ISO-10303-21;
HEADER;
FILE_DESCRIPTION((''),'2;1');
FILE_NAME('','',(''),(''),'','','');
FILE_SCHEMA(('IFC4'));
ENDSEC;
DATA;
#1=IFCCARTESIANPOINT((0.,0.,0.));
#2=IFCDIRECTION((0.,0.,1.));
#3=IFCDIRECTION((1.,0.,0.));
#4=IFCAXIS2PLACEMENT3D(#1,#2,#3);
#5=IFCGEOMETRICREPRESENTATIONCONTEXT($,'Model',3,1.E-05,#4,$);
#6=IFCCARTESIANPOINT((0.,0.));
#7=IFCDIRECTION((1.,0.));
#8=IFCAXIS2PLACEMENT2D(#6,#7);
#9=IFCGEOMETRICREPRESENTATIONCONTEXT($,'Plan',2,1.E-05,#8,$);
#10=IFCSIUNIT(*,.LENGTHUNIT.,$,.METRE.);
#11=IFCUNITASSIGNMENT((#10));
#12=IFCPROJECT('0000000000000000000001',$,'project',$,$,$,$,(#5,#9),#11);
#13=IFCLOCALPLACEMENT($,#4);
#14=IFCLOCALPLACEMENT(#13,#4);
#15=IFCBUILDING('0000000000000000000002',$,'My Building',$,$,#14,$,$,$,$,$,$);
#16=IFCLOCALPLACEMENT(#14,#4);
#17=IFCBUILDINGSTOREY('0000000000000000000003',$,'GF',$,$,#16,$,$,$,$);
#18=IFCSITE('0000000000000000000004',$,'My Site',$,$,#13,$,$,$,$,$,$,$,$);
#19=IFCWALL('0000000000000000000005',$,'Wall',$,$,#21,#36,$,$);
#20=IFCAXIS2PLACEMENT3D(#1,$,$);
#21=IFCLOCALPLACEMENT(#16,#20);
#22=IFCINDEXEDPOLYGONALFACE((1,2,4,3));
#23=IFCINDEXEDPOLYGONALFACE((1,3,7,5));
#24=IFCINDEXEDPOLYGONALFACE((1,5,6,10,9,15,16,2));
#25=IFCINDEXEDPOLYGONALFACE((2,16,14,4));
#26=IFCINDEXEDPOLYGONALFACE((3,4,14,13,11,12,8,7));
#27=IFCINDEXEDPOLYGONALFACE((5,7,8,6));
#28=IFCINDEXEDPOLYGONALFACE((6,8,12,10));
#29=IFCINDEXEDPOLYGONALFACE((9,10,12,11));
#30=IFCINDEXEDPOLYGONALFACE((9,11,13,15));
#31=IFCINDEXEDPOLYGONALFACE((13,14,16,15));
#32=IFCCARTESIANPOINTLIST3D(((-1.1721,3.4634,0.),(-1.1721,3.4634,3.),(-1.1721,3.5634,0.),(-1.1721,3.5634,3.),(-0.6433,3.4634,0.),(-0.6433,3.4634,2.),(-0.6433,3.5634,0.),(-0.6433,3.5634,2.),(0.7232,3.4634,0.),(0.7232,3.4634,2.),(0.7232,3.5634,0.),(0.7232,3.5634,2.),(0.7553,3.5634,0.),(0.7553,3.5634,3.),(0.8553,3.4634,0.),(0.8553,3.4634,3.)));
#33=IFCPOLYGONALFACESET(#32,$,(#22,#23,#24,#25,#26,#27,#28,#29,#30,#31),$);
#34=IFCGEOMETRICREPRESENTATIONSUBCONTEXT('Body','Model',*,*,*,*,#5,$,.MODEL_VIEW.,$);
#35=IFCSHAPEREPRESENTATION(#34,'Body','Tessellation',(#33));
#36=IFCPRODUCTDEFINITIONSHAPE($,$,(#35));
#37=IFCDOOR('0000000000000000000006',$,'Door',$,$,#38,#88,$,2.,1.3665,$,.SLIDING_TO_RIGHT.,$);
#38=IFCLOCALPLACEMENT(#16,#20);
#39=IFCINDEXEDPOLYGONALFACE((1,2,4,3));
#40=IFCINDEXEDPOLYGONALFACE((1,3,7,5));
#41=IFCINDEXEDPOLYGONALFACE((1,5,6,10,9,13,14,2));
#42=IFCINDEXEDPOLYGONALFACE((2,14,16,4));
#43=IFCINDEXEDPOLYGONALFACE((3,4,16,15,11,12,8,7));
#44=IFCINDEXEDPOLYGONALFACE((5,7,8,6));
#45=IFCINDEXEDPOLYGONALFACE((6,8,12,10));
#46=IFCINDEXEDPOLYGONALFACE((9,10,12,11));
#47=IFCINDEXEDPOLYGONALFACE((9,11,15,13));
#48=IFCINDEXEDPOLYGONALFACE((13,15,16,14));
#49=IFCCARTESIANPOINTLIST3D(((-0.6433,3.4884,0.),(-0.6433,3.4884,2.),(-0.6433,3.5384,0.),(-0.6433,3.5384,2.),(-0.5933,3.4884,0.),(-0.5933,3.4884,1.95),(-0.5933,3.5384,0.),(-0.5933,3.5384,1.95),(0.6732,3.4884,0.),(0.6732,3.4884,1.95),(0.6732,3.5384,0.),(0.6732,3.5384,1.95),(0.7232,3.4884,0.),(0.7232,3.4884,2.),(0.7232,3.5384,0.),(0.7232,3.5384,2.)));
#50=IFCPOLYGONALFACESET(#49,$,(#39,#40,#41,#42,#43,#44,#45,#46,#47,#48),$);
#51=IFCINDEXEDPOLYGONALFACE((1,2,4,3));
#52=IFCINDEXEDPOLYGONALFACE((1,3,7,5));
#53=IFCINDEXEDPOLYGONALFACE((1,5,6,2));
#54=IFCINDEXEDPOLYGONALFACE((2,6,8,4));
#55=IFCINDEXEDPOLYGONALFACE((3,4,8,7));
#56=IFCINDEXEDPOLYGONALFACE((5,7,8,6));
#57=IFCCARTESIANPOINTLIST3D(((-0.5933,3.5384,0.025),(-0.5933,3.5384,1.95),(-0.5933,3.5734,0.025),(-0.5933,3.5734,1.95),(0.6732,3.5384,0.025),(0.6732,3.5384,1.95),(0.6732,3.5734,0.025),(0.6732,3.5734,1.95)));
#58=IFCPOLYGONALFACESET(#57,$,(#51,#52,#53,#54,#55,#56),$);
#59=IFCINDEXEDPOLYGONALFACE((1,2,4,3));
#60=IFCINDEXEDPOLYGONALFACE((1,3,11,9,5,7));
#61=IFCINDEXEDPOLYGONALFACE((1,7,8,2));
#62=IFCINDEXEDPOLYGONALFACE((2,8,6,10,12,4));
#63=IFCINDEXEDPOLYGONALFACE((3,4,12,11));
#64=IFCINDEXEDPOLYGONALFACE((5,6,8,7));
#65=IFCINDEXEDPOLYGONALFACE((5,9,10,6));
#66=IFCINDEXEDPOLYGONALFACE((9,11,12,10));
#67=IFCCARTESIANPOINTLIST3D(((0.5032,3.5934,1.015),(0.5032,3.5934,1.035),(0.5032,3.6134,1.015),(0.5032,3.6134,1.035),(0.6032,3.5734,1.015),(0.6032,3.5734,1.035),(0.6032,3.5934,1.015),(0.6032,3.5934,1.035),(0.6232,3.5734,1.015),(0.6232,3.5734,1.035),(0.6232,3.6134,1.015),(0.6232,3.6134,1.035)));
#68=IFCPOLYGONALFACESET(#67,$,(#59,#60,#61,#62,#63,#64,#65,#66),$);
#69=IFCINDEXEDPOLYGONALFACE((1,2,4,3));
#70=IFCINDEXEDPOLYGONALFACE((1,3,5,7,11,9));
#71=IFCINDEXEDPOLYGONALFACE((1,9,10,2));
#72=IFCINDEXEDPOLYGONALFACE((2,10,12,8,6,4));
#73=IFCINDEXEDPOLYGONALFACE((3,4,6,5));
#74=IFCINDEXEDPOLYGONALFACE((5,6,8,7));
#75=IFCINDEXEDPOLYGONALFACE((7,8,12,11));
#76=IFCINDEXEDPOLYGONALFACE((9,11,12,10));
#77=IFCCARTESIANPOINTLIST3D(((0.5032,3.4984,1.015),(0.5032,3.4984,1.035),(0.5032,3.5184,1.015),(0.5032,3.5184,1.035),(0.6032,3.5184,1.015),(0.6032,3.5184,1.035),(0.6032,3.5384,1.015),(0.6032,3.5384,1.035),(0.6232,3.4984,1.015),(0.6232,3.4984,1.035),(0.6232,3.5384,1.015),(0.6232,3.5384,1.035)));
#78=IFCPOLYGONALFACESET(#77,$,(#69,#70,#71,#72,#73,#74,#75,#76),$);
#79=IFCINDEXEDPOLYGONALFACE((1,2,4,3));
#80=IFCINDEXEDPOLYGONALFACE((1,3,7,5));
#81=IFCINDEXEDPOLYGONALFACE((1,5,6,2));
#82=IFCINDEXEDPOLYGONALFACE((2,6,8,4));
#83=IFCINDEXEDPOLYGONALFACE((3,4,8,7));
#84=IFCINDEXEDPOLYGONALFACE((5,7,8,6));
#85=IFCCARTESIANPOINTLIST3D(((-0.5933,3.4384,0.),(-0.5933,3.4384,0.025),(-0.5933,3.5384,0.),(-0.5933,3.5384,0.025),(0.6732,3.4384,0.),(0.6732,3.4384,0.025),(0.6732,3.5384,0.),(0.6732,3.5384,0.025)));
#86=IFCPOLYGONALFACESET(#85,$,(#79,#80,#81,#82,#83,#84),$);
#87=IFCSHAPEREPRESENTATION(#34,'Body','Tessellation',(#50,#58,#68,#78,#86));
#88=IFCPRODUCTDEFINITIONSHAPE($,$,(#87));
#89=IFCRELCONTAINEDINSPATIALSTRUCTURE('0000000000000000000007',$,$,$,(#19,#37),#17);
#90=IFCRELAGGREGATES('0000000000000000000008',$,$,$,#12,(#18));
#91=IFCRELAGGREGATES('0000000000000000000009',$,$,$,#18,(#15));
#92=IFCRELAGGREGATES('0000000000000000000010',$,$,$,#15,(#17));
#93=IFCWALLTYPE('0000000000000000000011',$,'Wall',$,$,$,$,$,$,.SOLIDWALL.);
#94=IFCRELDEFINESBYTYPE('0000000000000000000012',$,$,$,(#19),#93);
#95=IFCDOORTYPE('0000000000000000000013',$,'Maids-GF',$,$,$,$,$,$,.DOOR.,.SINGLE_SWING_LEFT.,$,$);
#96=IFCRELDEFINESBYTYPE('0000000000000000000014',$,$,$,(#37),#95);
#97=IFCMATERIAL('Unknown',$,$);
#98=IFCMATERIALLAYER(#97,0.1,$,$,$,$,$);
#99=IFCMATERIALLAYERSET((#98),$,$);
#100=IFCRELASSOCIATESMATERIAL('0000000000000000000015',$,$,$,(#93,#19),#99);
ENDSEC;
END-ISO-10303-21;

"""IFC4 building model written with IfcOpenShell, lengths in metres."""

from ifc_helpers import new_model, entity, si_unit, frame, origin_with_axes, origin_2d_with_axis, place, context, subcontext, project, spatial, line, indexed_curve, outline, extrude, shape, source, transform, mapped, material, layer, layer_set, layer_usage, type_object, type_shapes, element, fill, save


model = new_model("IFC4")

# Units and contexts
model_context = context("Model", 3, precision=1e-05, world=origin_with_axes())
plan_context = context("Plan", 2, precision=1e-05, world=origin_2d_with_axis())
body_context_1 = subcontext(model_context, "Body", "Model", "MODEL_VIEW")
body_context_2 = subcontext(plan_context, "Body", "Plan", "PLAN_VIEW")
ifc_project = project(units=[si_unit("LENGTHUNIT", "METRE")], contexts=[model_context, plan_context])

# Site, building, storey
site_placement = place(None, origin_with_axes())
site = spatial("IfcSite", under=ifc_project, at=site_placement, Name="My Site")
building_placement = place(site_placement, origin_with_axes())
building = spatial("IfcBuilding", under=site, at=building_placement, Name="My Building")
storey_placement = place(building_placement, origin_with_axes())
storey = spatial("IfcBuildingStorey", under=building, at=storey_placement, Name="GF")

# Shared definitions
ifc_material = material(Name="Unknown")

# Shared definitions
ifc_layer_1 = layer(ifc_material, 0.1)
ifc_layer_set_1 = layer_set([ifc_layer_1])
wall_type = type_object("IfcWallType", Name="Wall", PredefinedType="SOLIDWALL", material=ifc_layer_set_1)

# Wall, opening, door
ifc_layer_usage_1 = layer_usage(ifc_layer_set_1, "AXIS2", "POSITIVE", 0.0)
wall_1_placement = place(storey_placement, frame((0.7553, 3.5634, 0.0), z_axis=(0.0, 0.0, 1.0), x_axis=(-1.0, 0.0, 0.0)))
wall_1 = element("IfcWall", 1, at=wall_1_placement, inside=storey, type_object=wall_type, material=ifc_layer_usage_1, Name="Wall", context=body_context_1, shape_type="SweptSolid", body=[
    extrude(outline(indexed_curve([(0.0, 0.0), (-0.1, 0.1), (1.9273, 0.1), (1.9273, 0.0)], segments=[line(1, 2, 3, 4, 1)])), origin_with_axes(), (0.0, 0.0, 1.0), 3.0),
])
shared_shape_1 = source(origin_with_axes(), body_context_1, "Body", "SweptSolid", [
    extrude(outline(indexed_curve([(0.0, 0.0), (1.3665, 0.0), (1.3665, 2.0), (0.0, 2.0)], segments=[line(1, 2, 3, 4, 1)])), frame((0.0, -0.6, 0.0), z_axis=(0.0, -1.0, 0.0), x_axis=(1.0, 0.0, 0.0)), (0.0, 0.0, -1.0), 1.2),
])
opening_1_placement = place(wall_1_placement, frame((0.0321, 0.025, 0.0), z_axis=(0.0, 0.0, 1.0), x_axis=(1.0, 0.0, 0.0)))
opening_1 = element("IfcOpeningElement", 2, at=opening_1_placement, cuts=wall_1, PredefinedType="OPENING", context=body_context_1, shape_type="MappedRepresentation", body=[
    mapped(shared_shape_1, transform((0.0, 0.0, 0.0), x_axis=(1.0, 0.0, 0.0), y_axis=(0.0, 1.0, 0.0), z_axis=(0.0, 0.0, 1.0), scale=1.0)),
])
door_type_1 = type_object("IfcDoorType", Name="Maids-GF", OperationType="SINGLE_SWING_LEFT", PredefinedType="DOOR")
shared_shape_2 = source(origin_with_axes(), body_context_1, "Body", "SweptSolid", [
    extrude(outline(indexed_curve([(0.0, 0.0), (0.0, 2.0), (1.3665, 2.0), (1.3665, 0.0), (1.3165, 0.0), (1.3165, 1.95), (0.05, 1.95), (0.05, 0.0)], segments=[line(1, 2, 3, 4, 5, 6, 7, 8, 1)])), frame((0.0, 0.0, 0.0), z_axis=(0.0, -1.0, 0.0), x_axis=(1.0, 0.0, 0.0)), (0.0, 0.0, -1.0), 0.05),
    extrude(outline(indexed_curve([(0.0, 0.0), (1.2665, 0.0), (1.2665, 0.035), (0.0, 0.035)], segments=[line(1, 2, 3, 4, 1)])), frame((0.05, -0.035, 0.025), z_axis=(0.0, 0.0, 1.0), x_axis=(1.0, 0.0, 0.0)), (0.0, 0.0, 1.0), 1.925),
    extrude(outline(indexed_curve([(0.0, 0.0), (0.0, -0.04), (0.12, -0.04), (0.12, -0.02), (0.02, -0.02), (0.02, 0.0)], segments=[line(1, 2, 3, 4, 5, 6, 1)])), frame((0.1, -0.035, 1.015), z_axis=(0.0, 0.0, 1.0), x_axis=(1.0, 0.0, 0.0)), (0.0, 0.0, 1.0), 0.02),
    extrude(outline(indexed_curve([(0.0, 0.0), (0.0, 0.04), (0.12, 0.04), (0.12, 0.02), (0.02, 0.02), (0.02, 0.0)], segments=[line(1, 2, 3, 4, 5, 6, 1)])), frame((0.1, 0.0, 1.015), z_axis=(0.0, 0.0, 1.0), x_axis=(1.0, 0.0, 0.0)), (0.0, 0.0, 1.0), 0.02),
    extrude(outline(indexed_curve([(0.0, 0.0), (1.2665, 0.0), (1.2665, 0.1), (0.0, 0.1)], segments=[line(1, 2, 3, 4, 1)])), frame((0.05, 0.0, 0.0), z_axis=(0.0, 0.0, 1.0), x_axis=(1.0, 0.0, 0.0)), (0.0, 0.0, 1.0), 0.025),
])
shared_shape_3 = source(origin_with_axes(), body_context_2, "Body", "Curve2D", [
    entity("IfcIndexedPolyCurve", entity("IfcCartesianPointList2D", [[0.0, 0.0], [0.05, 0.0], [0.05, 0.05], [0.0, 0.05]]), [entity("IfcLineIndex", [1, 2, 3, 4, 1])]),
    entity("IfcIndexedPolyCurve", entity("IfcCartesianPointList2D", [[1.3665, 0.0], [1.3165, 0.0], [1.3165, 0.05], [1.3665, 0.05]]), [entity("IfcLineIndex", [1, 2, 3, 4, 1])]),
    entity("IfcIndexedPolyCurve", entity("IfcCartesianPointList2D", [[1.9498, -0.035], [0.6833, -0.035], [0.6833, 0.0], [1.9498, 0.0]]), [entity("IfcLineIndex", [1, 2, 3, 4, 1])]),
])
type_shapes(door_type_1, [shared_shape_2, shared_shape_3])
door_1_placement = place(opening_1_placement, frame((0.0, 0.0, 0.0), z_axis=(0.0, 0.0, 1.0), x_axis=(1.0, 0.0, 0.0)))
door_1 = element("IfcDoor", 3, at=door_1_placement, inside=storey, type_object=door_type_1, Name="Door", OperationType="SLIDING_TO_RIGHT", OverallHeight=2.0, OverallWidth=1.3665, shapes=[
    shape(body_context_1, "Body", "MappedRepresentation", [mapped(shared_shape_2, transform((0.0, 0.0, 0.0), x_axis=(1.0, 0.0, 0.0), y_axis=(0.0, 1.0, 0.0), z_axis=(0.0, 0.0, 1.0), scale=1.0))]),
    shape(body_context_2, "Body", "MappedRepresentation", [mapped(shared_shape_3, transform((0.0, 0.0, 0.0), x_axis=(1.0, 0.0, 0.0), y_axis=(0.0, 1.0, 0.0), z_axis=(0.0, 0.0, 1.0), scale=1.0))]),
])
fill(opening_1, door_1)

save(model, "model.ifc")
